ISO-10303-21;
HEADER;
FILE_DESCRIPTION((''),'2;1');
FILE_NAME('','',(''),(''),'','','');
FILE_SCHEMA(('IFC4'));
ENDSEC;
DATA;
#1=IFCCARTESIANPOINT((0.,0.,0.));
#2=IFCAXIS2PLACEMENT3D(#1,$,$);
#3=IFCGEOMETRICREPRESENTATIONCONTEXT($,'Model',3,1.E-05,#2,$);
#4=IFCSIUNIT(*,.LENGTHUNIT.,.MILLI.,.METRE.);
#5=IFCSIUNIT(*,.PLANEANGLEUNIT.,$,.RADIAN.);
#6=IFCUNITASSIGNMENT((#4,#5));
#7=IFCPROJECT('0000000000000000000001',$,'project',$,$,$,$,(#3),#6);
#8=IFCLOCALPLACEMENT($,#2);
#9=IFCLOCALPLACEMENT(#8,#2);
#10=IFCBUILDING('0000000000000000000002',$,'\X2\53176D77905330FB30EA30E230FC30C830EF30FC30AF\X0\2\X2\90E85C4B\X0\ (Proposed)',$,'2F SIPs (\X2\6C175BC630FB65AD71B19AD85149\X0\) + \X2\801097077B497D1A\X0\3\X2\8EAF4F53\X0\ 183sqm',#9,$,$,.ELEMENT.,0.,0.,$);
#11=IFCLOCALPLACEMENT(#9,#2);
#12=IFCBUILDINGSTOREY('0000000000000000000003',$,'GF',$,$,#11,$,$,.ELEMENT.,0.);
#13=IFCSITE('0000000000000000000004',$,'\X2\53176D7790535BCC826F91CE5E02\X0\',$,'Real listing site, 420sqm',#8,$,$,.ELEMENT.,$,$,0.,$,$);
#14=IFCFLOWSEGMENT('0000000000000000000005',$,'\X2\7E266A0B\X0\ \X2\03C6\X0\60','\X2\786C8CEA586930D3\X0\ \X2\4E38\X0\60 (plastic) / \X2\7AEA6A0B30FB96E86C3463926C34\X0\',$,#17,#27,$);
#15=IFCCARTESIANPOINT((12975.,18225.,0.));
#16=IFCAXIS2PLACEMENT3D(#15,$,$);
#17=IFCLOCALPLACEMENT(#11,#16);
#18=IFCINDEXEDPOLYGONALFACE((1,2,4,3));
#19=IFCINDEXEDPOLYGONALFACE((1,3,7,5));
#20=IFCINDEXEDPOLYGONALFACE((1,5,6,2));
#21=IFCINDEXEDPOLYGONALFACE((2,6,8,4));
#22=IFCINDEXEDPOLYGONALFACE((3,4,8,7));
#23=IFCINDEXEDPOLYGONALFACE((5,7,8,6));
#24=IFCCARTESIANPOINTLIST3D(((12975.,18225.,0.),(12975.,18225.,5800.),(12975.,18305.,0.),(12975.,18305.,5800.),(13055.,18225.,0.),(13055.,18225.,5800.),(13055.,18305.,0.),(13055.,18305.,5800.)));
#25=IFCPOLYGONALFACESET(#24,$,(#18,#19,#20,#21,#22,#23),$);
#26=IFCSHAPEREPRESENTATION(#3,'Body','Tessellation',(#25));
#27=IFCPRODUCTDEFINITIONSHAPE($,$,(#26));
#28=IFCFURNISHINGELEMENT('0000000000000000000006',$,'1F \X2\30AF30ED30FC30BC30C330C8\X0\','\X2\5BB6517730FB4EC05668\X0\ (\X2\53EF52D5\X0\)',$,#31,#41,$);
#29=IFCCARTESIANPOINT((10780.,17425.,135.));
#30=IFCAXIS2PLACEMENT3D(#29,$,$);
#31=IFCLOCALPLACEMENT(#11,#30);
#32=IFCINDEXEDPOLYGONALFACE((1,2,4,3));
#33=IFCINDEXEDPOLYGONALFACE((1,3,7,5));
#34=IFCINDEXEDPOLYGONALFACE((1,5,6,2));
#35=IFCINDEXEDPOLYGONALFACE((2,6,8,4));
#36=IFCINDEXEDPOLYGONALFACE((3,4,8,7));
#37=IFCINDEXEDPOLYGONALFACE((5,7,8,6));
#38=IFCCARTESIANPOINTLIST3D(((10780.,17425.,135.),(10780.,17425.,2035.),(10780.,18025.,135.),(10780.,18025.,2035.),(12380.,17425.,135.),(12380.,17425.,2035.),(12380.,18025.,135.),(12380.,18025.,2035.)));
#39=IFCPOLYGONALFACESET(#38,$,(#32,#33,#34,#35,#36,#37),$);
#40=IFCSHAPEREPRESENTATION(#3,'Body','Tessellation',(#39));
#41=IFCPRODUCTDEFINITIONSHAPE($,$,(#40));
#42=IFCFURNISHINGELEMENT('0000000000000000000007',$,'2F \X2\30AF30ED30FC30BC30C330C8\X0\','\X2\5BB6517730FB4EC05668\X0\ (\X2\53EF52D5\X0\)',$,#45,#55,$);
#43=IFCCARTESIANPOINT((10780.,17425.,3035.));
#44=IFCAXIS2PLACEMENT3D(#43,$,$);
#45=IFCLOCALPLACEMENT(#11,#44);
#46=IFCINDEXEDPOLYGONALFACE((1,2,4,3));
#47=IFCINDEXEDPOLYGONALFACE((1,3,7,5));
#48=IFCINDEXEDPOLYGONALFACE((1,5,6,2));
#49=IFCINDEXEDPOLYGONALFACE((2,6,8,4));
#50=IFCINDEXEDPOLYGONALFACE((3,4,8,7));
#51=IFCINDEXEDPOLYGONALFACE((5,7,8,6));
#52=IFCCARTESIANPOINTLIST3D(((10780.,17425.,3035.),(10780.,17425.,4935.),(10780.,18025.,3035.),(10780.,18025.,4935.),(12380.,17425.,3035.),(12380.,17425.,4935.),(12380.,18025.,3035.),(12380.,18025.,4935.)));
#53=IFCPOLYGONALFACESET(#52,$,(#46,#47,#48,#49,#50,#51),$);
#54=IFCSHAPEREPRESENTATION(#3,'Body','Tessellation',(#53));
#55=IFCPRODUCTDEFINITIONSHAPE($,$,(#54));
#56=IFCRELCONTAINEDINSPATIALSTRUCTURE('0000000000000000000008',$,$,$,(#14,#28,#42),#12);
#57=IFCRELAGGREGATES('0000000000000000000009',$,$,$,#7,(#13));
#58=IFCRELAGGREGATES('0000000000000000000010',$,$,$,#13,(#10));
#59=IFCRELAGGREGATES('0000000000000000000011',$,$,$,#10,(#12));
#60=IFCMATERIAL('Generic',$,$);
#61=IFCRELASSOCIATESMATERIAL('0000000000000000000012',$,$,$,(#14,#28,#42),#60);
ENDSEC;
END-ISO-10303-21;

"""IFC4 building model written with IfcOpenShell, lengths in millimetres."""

from ifc_helpers import new_model, si_unit, frame, frame_2d, origin, place, context, project, spatial, rectangle, extrude, material, element, save


model = new_model("IFC4")

# Units and contexts
model_context = context("Model", 3, precision=1e-05, world=origin())
ifc_project = project(units=[si_unit("LENGTHUNIT", "METRE", prefix="MILLI"), si_unit("PLANEANGLEUNIT", "RADIAN")], contexts=[model_context])

# Site, building, storey
site_placement = place(None, origin())
site = spatial("IfcSite", under=ifc_project, at=site_placement, Name="北海道富良野市", ObjectType="Real listing site, 420sqm", CompositionType="ELEMENT", RefElevation=0.0)
building_placement = place(site_placement, origin())
building = spatial("IfcBuilding", under=site, at=building_placement, Name="北海道・リモートワーク2部屋 (Proposed)", ObjectType="2F SIPs (気密・断熱高光) + 耐震等級3躯体 183sqm", CompositionType="ELEMENT", ElevationOfRefHeight=0.0, ElevationOfTerrain=0.0)
storey_placement = place(building_placement, origin())
storey = spatial("IfcBuildingStorey", under=building, at=storey_placement, Name="GF", CompositionType="ELEMENT", Elevation=0.0)

# Shared definitions
ifc_material_1 = material(Name="Generic")

# Flow segment
flow_segment_placement = place(storey_placement, frame((12975.0, 18225.0, 0.0)))
element("IfcFlowSegment", 1, at=flow_segment_placement, inside=storey, material=ifc_material_1, Name="縦樋 φ60", Description="硬質塩ビ 丸60 (plastic) / 竪樋・雨水排水", context=model_context, shape_type="SweptSolid", body=[
    extrude(rectangle(XDim=80.0, YDim=80.0, at=frame_2d((40.0, 40.0))), frame((12975.0, 18225.0, 0.0)), (0.0, 0.0, 1.0), 5800.0),
])

# Furnishing elements
furnishing_1_placement = place(storey_placement, frame((10780.0, 17425.0, 135.0)))
element("IfcFurnishingElement", 2, at=furnishing_1_placement, inside=storey, material=ifc_material_1, Name="1F クローゼット", Description="家具・什器 (可動)", context=model_context, shape_type="SweptSolid", body=[
    extrude(rectangle(XDim=1600.0, YDim=600.0, at=frame_2d((800.0, 300.0))), frame((10780.0, 17425.0, 135.0)), (0.0, 0.0, 1.0), 1900.0),
])
furnishing_2_placement = place(storey_placement, frame((10780.0, 17425.0, 3035.0)))
element("IfcFurnishingElement", 3, at=furnishing_2_placement, inside=storey, material=ifc_material_1, Name="2F クローゼット", Description="家具・什器 (可動)", context=model_context, shape_type="SweptSolid", body=[
    extrude(rectangle(XDim=1600.0, YDim=600.0, at=frame_2d((800.0, 300.0))), frame((10780.0, 17425.0, 3035.0)), (0.0, 0.0, 1.0), 1900.0),
])

save(model, "model.ifc")
